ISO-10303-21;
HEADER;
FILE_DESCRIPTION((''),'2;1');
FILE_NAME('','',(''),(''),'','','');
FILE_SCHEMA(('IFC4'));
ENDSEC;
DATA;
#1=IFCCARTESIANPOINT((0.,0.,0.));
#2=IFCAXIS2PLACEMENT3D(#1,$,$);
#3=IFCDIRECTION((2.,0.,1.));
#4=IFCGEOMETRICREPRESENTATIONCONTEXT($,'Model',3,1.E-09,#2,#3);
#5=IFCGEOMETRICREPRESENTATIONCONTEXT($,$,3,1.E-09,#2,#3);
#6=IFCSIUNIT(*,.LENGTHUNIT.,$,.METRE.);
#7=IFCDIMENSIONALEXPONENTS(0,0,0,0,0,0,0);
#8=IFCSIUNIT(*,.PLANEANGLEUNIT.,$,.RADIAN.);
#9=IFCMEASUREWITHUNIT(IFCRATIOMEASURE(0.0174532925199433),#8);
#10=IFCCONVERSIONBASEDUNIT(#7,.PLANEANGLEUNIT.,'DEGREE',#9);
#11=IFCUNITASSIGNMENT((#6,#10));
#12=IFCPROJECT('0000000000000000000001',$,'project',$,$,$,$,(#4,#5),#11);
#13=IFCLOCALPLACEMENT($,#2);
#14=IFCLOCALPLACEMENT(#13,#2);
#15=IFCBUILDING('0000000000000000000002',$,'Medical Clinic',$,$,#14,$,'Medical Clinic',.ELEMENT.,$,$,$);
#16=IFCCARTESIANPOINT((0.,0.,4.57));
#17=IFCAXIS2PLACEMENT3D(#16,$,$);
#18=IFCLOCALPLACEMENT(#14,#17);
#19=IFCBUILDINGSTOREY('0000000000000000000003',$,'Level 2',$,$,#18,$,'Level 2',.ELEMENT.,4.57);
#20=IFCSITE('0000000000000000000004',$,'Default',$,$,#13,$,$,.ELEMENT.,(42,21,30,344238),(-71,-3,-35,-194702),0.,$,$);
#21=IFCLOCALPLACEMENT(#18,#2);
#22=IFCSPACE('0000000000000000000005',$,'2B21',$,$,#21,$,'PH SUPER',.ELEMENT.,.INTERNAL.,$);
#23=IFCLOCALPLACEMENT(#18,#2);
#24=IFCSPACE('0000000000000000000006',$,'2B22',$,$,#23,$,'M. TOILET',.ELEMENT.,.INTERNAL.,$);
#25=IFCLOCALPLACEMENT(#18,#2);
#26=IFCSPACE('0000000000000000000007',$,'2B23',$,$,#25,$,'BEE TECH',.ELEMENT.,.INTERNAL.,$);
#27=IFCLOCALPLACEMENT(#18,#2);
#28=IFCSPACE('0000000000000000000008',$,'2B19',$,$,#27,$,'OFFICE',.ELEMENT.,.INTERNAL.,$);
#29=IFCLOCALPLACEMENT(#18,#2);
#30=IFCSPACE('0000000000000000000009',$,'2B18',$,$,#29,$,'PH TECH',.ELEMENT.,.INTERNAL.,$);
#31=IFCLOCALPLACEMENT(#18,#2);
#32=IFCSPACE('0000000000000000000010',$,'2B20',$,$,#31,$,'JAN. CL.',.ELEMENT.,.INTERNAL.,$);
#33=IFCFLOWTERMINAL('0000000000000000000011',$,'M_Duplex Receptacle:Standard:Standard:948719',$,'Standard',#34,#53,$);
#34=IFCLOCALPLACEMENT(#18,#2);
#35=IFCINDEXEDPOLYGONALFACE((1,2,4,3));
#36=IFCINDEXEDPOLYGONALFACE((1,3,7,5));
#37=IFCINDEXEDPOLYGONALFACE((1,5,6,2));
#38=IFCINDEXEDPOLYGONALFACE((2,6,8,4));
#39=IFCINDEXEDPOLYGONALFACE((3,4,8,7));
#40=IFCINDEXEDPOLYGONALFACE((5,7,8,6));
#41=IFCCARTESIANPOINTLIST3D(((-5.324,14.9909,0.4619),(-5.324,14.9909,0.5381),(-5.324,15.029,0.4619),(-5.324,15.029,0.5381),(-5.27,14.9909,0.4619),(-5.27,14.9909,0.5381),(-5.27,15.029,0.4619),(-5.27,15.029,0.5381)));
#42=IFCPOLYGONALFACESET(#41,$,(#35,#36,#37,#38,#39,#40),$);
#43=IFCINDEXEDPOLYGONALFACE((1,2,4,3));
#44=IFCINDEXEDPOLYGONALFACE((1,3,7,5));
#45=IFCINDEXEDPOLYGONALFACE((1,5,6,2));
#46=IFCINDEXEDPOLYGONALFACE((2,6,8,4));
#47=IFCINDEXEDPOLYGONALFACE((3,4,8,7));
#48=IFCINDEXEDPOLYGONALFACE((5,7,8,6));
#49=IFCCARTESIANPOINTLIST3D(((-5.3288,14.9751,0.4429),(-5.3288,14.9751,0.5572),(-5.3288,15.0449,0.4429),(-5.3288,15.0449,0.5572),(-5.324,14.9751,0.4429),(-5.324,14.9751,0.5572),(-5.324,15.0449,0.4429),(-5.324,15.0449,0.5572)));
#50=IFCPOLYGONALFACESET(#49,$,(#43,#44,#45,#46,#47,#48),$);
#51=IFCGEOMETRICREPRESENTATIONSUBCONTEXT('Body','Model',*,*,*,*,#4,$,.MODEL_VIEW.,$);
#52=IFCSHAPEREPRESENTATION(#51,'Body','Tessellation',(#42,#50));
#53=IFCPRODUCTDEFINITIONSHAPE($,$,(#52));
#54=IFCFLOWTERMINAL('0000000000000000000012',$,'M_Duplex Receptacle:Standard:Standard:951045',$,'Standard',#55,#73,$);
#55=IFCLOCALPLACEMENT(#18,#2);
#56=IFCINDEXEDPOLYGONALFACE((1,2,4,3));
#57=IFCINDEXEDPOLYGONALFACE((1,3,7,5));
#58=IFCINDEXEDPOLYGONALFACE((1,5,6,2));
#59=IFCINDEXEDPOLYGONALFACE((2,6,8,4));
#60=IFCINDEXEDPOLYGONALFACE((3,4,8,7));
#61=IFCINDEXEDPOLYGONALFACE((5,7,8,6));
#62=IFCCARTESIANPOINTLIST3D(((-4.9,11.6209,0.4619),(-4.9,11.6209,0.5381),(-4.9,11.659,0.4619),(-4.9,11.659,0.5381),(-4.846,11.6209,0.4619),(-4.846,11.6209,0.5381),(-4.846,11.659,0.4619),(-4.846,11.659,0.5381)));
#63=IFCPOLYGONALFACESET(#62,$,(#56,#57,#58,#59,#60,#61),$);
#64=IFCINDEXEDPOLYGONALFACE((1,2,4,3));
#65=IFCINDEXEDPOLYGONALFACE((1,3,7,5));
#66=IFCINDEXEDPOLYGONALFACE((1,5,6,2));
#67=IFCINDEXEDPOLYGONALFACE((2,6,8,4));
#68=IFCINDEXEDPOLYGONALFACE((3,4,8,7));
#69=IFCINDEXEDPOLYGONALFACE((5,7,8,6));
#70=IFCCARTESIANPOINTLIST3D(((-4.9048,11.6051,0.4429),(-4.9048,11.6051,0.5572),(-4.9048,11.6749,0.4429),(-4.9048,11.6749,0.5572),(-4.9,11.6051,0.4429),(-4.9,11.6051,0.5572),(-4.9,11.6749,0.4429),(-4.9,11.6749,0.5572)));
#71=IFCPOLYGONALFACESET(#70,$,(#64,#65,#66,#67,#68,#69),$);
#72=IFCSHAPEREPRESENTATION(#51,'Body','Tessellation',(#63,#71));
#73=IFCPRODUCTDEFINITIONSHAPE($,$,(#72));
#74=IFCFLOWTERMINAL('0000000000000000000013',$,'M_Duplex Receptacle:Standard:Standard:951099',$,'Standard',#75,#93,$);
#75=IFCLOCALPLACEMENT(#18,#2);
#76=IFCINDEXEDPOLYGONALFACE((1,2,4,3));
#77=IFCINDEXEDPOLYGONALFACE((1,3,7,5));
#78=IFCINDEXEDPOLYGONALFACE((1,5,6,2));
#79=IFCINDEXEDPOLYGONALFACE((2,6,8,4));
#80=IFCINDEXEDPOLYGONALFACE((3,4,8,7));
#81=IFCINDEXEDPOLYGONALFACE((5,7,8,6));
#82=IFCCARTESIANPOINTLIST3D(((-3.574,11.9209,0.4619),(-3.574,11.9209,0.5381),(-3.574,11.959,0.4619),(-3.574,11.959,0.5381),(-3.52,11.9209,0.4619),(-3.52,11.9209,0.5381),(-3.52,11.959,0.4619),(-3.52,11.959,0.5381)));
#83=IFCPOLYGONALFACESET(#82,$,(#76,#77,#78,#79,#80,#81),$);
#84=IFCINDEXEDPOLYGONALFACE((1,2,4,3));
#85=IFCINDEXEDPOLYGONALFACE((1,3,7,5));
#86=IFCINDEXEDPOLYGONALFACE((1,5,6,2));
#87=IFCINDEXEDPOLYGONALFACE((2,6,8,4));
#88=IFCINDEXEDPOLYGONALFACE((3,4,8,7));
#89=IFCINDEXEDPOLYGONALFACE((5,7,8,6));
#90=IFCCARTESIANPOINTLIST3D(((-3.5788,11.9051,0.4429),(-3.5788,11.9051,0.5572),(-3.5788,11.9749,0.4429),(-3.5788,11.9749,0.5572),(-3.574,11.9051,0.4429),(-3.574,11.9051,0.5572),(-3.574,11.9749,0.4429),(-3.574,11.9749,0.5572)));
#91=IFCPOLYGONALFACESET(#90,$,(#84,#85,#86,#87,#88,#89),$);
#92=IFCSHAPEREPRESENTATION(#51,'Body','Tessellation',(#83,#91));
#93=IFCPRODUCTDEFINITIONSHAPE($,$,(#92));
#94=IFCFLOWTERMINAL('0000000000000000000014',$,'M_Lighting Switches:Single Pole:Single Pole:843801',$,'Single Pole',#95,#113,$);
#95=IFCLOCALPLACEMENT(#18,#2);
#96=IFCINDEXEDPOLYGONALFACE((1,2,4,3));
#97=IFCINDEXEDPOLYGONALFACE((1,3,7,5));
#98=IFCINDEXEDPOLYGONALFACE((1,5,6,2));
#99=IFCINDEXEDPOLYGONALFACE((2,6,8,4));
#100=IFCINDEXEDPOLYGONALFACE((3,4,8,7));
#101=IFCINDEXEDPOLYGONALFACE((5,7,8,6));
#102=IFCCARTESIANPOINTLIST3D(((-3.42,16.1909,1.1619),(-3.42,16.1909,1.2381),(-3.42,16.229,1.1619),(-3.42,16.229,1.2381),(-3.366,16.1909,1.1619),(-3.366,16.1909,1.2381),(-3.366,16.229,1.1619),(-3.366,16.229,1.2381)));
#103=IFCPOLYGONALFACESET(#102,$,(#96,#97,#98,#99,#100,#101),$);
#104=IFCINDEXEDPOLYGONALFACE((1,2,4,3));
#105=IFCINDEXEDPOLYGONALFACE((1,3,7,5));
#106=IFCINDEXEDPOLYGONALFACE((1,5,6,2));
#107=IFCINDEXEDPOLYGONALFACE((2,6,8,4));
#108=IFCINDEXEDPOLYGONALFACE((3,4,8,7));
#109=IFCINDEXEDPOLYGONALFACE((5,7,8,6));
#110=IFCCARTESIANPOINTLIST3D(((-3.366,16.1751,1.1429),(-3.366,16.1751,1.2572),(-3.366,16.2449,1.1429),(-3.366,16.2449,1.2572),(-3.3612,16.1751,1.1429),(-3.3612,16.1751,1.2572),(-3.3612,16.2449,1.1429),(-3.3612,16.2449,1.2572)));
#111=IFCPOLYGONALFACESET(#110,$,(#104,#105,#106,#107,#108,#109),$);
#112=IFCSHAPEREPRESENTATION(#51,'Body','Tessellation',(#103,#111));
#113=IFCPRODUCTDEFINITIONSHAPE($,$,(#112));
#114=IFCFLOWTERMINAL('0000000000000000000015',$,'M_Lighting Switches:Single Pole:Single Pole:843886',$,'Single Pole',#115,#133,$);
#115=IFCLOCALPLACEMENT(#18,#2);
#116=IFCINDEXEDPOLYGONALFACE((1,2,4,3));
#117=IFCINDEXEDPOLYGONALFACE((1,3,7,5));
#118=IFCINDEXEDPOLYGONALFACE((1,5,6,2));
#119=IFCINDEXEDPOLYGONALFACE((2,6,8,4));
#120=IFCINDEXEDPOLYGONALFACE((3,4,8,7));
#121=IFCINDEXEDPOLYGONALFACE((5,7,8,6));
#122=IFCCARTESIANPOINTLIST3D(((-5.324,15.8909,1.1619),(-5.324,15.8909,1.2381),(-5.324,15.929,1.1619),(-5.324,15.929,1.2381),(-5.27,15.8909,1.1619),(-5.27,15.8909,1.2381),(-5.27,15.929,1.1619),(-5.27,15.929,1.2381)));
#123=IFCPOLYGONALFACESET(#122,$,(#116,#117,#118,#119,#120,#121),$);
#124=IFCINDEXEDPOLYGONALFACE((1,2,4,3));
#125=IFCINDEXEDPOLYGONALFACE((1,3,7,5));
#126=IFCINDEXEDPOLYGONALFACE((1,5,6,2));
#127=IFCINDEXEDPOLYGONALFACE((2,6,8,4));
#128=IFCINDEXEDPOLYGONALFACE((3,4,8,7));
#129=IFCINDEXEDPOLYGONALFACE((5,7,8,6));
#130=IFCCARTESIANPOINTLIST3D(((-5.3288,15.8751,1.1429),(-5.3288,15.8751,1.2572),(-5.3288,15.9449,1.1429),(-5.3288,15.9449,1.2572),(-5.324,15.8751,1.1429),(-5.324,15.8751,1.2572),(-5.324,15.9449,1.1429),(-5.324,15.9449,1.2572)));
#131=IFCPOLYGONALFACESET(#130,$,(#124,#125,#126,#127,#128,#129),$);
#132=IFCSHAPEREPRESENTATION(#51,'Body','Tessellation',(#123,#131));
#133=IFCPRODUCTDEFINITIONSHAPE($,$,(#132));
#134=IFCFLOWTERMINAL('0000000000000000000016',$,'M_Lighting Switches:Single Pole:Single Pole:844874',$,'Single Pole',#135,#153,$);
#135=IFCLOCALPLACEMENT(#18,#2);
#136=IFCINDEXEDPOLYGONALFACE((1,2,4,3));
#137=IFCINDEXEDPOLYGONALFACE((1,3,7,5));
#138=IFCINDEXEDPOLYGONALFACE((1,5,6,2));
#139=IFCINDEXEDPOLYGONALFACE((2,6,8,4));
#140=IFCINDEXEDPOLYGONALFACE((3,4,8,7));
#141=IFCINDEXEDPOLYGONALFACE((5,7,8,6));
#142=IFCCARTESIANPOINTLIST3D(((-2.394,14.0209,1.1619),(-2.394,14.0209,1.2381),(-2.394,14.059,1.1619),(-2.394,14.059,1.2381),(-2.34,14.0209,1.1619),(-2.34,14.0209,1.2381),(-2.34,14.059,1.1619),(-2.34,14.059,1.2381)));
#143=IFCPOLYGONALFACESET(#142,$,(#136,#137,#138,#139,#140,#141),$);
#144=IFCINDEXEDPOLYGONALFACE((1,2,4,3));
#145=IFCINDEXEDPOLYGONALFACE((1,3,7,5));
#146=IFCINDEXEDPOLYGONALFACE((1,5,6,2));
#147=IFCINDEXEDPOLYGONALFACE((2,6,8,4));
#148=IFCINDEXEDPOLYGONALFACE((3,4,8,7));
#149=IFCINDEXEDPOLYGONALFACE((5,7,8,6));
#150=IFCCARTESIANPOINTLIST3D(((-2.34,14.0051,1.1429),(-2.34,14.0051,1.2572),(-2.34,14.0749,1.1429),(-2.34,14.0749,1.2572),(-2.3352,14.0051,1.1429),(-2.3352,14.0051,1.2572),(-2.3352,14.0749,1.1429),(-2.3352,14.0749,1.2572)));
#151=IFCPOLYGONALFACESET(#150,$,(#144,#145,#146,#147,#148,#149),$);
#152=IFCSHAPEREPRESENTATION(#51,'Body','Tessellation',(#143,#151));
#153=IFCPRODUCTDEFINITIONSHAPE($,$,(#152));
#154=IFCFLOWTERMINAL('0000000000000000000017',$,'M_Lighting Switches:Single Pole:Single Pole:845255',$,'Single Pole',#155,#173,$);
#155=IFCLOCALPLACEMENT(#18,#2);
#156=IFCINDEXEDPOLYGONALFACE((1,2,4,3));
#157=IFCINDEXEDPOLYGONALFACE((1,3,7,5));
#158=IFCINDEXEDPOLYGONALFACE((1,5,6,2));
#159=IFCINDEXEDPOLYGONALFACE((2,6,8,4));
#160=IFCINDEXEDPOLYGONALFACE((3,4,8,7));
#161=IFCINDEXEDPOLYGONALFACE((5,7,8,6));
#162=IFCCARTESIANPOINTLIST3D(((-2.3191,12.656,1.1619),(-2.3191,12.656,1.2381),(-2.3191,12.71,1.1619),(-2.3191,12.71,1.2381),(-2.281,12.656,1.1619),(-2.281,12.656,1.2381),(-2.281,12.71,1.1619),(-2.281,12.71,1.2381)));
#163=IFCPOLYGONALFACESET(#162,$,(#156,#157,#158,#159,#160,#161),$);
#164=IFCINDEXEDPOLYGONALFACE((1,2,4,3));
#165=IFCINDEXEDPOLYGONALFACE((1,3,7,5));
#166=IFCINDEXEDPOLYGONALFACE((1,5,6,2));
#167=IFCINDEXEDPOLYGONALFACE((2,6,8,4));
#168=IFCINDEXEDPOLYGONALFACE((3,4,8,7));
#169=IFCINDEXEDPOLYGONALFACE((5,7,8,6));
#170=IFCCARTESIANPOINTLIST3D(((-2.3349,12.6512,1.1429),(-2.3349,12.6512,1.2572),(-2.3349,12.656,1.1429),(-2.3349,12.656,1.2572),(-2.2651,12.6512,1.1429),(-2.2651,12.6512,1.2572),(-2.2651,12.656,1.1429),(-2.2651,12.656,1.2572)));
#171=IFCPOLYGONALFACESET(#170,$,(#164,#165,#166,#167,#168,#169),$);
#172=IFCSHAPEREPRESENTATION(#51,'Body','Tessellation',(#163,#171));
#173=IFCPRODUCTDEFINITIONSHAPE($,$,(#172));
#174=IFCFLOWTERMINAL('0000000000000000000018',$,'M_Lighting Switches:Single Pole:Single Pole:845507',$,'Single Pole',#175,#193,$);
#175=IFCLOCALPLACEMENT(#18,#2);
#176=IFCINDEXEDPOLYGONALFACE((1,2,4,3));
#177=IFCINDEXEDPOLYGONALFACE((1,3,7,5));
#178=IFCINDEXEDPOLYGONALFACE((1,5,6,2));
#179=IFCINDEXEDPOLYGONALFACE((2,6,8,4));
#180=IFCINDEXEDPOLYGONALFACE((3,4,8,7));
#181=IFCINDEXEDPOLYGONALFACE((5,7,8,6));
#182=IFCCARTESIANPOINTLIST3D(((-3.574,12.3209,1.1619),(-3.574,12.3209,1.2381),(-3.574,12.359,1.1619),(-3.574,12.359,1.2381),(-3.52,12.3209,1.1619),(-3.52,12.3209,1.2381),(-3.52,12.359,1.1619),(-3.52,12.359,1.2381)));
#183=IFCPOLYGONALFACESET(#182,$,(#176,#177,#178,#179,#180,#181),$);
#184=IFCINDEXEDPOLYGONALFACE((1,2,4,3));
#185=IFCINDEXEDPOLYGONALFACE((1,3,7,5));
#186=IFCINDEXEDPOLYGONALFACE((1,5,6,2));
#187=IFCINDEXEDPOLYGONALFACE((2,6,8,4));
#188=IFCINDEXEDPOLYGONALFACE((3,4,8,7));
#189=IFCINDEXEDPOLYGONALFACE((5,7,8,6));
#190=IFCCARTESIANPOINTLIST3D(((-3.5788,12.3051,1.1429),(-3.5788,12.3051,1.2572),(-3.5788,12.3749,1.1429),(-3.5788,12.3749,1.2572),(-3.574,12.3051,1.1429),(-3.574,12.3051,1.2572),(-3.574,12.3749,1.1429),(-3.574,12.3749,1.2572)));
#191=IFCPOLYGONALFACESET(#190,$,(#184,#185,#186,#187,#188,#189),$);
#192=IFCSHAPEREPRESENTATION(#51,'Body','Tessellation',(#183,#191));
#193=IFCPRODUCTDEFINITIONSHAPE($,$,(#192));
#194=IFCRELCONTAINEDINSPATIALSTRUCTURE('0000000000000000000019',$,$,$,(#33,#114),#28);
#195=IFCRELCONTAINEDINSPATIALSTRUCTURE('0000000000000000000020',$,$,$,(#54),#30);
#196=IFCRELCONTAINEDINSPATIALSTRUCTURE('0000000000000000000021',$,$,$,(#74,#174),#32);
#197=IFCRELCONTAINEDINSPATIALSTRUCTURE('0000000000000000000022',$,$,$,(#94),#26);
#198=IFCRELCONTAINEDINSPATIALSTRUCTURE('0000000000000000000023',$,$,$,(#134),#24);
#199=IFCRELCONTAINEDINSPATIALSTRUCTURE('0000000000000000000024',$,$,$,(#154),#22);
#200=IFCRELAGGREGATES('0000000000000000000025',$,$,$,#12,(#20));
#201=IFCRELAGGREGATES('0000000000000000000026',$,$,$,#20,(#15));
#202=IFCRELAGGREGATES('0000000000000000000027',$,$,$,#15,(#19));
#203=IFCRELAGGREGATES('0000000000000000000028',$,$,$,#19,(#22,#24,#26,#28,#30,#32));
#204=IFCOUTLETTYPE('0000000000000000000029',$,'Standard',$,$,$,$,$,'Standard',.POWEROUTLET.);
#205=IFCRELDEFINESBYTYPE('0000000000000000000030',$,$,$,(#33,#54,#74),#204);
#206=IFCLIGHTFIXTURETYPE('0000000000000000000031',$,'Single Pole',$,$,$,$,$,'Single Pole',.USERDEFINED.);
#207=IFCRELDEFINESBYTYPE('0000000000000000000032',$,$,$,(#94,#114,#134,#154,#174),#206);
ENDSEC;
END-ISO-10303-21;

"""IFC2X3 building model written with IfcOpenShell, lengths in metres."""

from ifc_helpers import new_model, entity, si_unit, converted_unit, direction, frame, frame_2d, origin, origin_2d_with_axis, place, context, subcontext, project, spatial, rectangle, extrude, source, transform, mapped, type_object, type_shapes, element, save


model = new_model("IFC2X3")

# Units and contexts
model_context = context("Model", 3, precision=1e-09, world=origin(), true_north=direction((2.0, 0.0, 1.0)))
context_of_model = context(None, 3, precision=1e-09, world=origin(), true_north=direction((2.0, 0.0, 1.0)))
body_context = subcontext(model_context, "Body", "Model", "MODEL_VIEW")
ifc_project = project(units=[si_unit("LENGTHUNIT", "METRE"), converted_unit("PLANEANGLEUNIT", "DEGREE", entity("IfcRatioMeasure", 0.0174532925199433), si_unit("PLANEANGLEUNIT", "RADIAN"), dimensions=[0, 0, 0, 0, 0, 0, 0])], contexts=[model_context, context_of_model])

# Site, building, storey, space
site_placement = place(None, origin())
site = spatial("IfcSite", under=ifc_project, at=site_placement, Name="Default", CompositionType="ELEMENT", RefLatitude=(42, 21, 30, 344238), RefLongitude=(-71, -3, -35, -194702), RefElevation=0.0)
building_placement = place(site_placement, origin())
building = spatial("IfcBuilding", under=site, at=building_placement, Name="Medical Clinic", LongName="Medical Clinic", CompositionType="ELEMENT")
storey_placement = place(building_placement, frame((0.0, 0.0, 4.57)))
storey = spatial("IfcBuildingStorey", under=building, at=storey_placement, Name="Level 2", LongName="Level 2", CompositionType="ELEMENT", Elevation=4.57)
space_1_placement = place(storey_placement, origin())
space_1 = spatial("IfcSpace", under=storey, at=space_1_placement, Name="2B21", LongName="PH SUPER", CompositionType="ELEMENT", InteriorOrExteriorSpace="INTERNAL")

# Shared definitions
outlet_type_1 = type_object("IfcOutletType", Name="Standard", ElementType="Standard", PredefinedType="POWEROUTLET")
shared_shape_1 = source(origin(), body_context, "Body", "SweptSolid", [
    extrude(rectangle(XDim=0.0381, YDim=0.0762, at=origin_2d_with_axis()), frame((0.0, 0.0, -0.054), z_axis=(0.0, 0.0, 1.0), x_axis=(-1.0, 0.0, 0.0)), (0.0, 0.0, 1.0), 0.054),
    extrude(rectangle(XDim=0.0698, YDim=0.1143, at=frame_2d((0.0, 0.0), x_axis=(1.0, 0.0))), frame((0.0, 0.0, 0.0), z_axis=(0.0, 0.0, 1.0), x_axis=(-1.0, 0.0, 0.0)), (0.0, 0.0, 1.0), 0.0048),
])
type_shapes(outlet_type_1, [shared_shape_1])

# Shared definitions
space_2_placement = place(storey_placement, origin())
space_2 = spatial("IfcSpace", under=storey, at=space_2_placement, Name="2B22", LongName="M. TOILET", CompositionType="ELEMENT", InteriorOrExteriorSpace="INTERNAL")

# Shared definitions
space_3_placement = place(storey_placement, origin())
space_3 = spatial("IfcSpace", under=storey, at=space_3_placement, Name="2B23", LongName="BEE TECH", CompositionType="ELEMENT", InteriorOrExteriorSpace="INTERNAL")

# Shared definitions
space_4_placement = place(storey_placement, origin())
space_4 = spatial("IfcSpace", under=storey, at=space_4_placement, Name="2B19", LongName="OFFICE", CompositionType="ELEMENT", InteriorOrExteriorSpace="INTERNAL")

# Flow terminal
flow_terminal_1_placement = place(space_4_placement, frame((-5.324, 15.01, 0.5), z_axis=(-1.0, 0.0, 0.0), x_axis=(0.0, -1.0, 0.0)))
element("IfcFlowTerminal", 1, at=flow_terminal_1_placement, inside=space_4, type_object=outlet_type_1, Name="M_Duplex Receptacle:Standard:Standard:948719", ObjectType="Standard", context=body_context, shape_type="MappedRepresentation", body=[
    mapped(shared_shape_1, transform((0.0, 0.0, 0.0), scale=1.0)),
])

# Shared definitions
space_5_placement = place(storey_placement, origin())
space_5 = spatial("IfcSpace", under=storey, at=space_5_placement, Name="2B18", LongName="PH TECH", CompositionType="ELEMENT", InteriorOrExteriorSpace="INTERNAL")

# Flow terminal
flow_terminal_2_placement = place(space_5_placement, frame((-4.9, 11.64, 0.5), z_axis=(-1.0, 0.0, 0.0), x_axis=(0.0, -1.0, 0.0)))
element("IfcFlowTerminal", 2, at=flow_terminal_2_placement, inside=space_5, type_object=outlet_type_1, Name="M_Duplex Receptacle:Standard:Standard:951045", ObjectType="Standard", context=body_context, shape_type="MappedRepresentation", body=[
    mapped(shared_shape_1, transform((0.0, 0.0, 0.0), scale=1.0)),
])

# Shared definitions
space_6_placement = place(storey_placement, origin())
space_6 = spatial("IfcSpace", under=storey, at=space_6_placement, Name="2B20", LongName="JAN. CL.", CompositionType="ELEMENT", InteriorOrExteriorSpace="INTERNAL")

# Flow terminals
flow_terminal_3_placement = place(space_6_placement, frame((-3.574, 11.94, 0.5), z_axis=(-1.0, 0.0, 0.0), x_axis=(0.0, -1.0, 0.0)))
element("IfcFlowTerminal", 3, at=flow_terminal_3_placement, inside=space_6, type_object=outlet_type_1, Name="M_Duplex Receptacle:Standard:Standard:951099", ObjectType="Standard", context=body_context, shape_type="MappedRepresentation", body=[
    mapped(shared_shape_1, transform((0.0, 0.0, 0.0), scale=1.0)),
])
light_fixture_type_1 = type_object("IfcLightFixtureType", Name="Single Pole", ElementType="Single Pole", PredefinedType="USERDEFINED")
shared_shape_2 = source(origin(), body_context, "Body", "SweptSolid", [
    extrude(rectangle(XDim=0.0381, YDim=0.0762, at=origin_2d_with_axis()), frame((0.0, 0.0, -0.054), z_axis=(0.0, 0.0, 1.0), x_axis=(-1.0, 0.0, 0.0)), (0.0, 0.0, 1.0), 0.054),
    extrude(rectangle(XDim=0.0698, YDim=0.1143, at=frame_2d((0.0, 0.0), x_axis=(1.0, 0.0))), frame((0.0, 0.0, 0.0), z_axis=(0.0, 0.0, 1.0), x_axis=(-1.0, 0.0, 0.0)), (0.0, 0.0, 1.0), 0.0048),
])
type_shapes(light_fixture_type_1, [shared_shape_2])
flow_terminal_4_placement = place(space_3_placement, frame((-3.366, 16.21, 1.2), z_axis=(1.0, 0.0, 0.0), x_axis=(0.0, 1.0, 0.0)))
element("IfcFlowTerminal", 4, at=flow_terminal_4_placement, inside=space_3, type_object=light_fixture_type_1, Name="M_Lighting Switches:Single Pole:Single Pole:843801", ObjectType="Single Pole", context=body_context, shape_type="MappedRepresentation", body=[
    mapped(shared_shape_2, transform((0.0, 0.0, 0.0), scale=1.0)),
])
flow_terminal_5_placement = place(space_4_placement, frame((-5.324, 15.91, 1.2), z_axis=(-1.0, 0.0, 0.0), x_axis=(0.0, -1.0, 0.0)))
element("IfcFlowTerminal", 5, at=flow_terminal_5_placement, inside=space_4, type_object=light_fixture_type_1, Name="M_Lighting Switches:Single Pole:Single Pole:843886", ObjectType="Single Pole", context=body_context, shape_type="MappedRepresentation", body=[
    mapped(shared_shape_2, transform((0.0, 0.0, 0.0), scale=1.0)),
])
flow_terminal_6_placement = place(space_2_placement, frame((-2.34, 14.04, 1.2), z_axis=(1.0, 0.0, 0.0), x_axis=(0.0, 1.0, 0.0)))
element("IfcFlowTerminal", 6, at=flow_terminal_6_placement, inside=space_2, type_object=light_fixture_type_1, Name="M_Lighting Switches:Single Pole:Single Pole:844874", ObjectType="Single Pole", context=body_context, shape_type="MappedRepresentation", body=[
    mapped(shared_shape_2, transform((0.0, 0.0, 0.0), scale=1.0)),
])
flow_terminal_7_placement = place(space_1_placement, frame((-2.3, 12.656, 1.2), z_axis=(0.0, -1.0, 0.0), x_axis=(1.0, 0.0, 0.0)))
element("IfcFlowTerminal", 7, at=flow_terminal_7_placement, inside=space_1, type_object=light_fixture_type_1, Name="M_Lighting Switches:Single Pole:Single Pole:845255", ObjectType="Single Pole", context=body_context, shape_type="MappedRepresentation", body=[
    mapped(shared_shape_2, transform((0.0, 0.0, 0.0), scale=1.0)),
])
flow_terminal_8_placement = place(space_6_placement, frame((-3.574, 12.34, 1.2), z_axis=(-1.0, 0.0, 0.0), x_axis=(0.0, -1.0, 0.0)))
element("IfcFlowTerminal", 8, at=flow_terminal_8_placement, inside=space_6, type_object=light_fixture_type_1, Name="M_Lighting Switches:Single Pole:Single Pole:845507", ObjectType="Single Pole", context=body_context, shape_type="MappedRepresentation", body=[
    mapped(shared_shape_2, transform((0.0, 0.0, 0.0), scale=1.0)),
])

save(model, "model.ifc")
